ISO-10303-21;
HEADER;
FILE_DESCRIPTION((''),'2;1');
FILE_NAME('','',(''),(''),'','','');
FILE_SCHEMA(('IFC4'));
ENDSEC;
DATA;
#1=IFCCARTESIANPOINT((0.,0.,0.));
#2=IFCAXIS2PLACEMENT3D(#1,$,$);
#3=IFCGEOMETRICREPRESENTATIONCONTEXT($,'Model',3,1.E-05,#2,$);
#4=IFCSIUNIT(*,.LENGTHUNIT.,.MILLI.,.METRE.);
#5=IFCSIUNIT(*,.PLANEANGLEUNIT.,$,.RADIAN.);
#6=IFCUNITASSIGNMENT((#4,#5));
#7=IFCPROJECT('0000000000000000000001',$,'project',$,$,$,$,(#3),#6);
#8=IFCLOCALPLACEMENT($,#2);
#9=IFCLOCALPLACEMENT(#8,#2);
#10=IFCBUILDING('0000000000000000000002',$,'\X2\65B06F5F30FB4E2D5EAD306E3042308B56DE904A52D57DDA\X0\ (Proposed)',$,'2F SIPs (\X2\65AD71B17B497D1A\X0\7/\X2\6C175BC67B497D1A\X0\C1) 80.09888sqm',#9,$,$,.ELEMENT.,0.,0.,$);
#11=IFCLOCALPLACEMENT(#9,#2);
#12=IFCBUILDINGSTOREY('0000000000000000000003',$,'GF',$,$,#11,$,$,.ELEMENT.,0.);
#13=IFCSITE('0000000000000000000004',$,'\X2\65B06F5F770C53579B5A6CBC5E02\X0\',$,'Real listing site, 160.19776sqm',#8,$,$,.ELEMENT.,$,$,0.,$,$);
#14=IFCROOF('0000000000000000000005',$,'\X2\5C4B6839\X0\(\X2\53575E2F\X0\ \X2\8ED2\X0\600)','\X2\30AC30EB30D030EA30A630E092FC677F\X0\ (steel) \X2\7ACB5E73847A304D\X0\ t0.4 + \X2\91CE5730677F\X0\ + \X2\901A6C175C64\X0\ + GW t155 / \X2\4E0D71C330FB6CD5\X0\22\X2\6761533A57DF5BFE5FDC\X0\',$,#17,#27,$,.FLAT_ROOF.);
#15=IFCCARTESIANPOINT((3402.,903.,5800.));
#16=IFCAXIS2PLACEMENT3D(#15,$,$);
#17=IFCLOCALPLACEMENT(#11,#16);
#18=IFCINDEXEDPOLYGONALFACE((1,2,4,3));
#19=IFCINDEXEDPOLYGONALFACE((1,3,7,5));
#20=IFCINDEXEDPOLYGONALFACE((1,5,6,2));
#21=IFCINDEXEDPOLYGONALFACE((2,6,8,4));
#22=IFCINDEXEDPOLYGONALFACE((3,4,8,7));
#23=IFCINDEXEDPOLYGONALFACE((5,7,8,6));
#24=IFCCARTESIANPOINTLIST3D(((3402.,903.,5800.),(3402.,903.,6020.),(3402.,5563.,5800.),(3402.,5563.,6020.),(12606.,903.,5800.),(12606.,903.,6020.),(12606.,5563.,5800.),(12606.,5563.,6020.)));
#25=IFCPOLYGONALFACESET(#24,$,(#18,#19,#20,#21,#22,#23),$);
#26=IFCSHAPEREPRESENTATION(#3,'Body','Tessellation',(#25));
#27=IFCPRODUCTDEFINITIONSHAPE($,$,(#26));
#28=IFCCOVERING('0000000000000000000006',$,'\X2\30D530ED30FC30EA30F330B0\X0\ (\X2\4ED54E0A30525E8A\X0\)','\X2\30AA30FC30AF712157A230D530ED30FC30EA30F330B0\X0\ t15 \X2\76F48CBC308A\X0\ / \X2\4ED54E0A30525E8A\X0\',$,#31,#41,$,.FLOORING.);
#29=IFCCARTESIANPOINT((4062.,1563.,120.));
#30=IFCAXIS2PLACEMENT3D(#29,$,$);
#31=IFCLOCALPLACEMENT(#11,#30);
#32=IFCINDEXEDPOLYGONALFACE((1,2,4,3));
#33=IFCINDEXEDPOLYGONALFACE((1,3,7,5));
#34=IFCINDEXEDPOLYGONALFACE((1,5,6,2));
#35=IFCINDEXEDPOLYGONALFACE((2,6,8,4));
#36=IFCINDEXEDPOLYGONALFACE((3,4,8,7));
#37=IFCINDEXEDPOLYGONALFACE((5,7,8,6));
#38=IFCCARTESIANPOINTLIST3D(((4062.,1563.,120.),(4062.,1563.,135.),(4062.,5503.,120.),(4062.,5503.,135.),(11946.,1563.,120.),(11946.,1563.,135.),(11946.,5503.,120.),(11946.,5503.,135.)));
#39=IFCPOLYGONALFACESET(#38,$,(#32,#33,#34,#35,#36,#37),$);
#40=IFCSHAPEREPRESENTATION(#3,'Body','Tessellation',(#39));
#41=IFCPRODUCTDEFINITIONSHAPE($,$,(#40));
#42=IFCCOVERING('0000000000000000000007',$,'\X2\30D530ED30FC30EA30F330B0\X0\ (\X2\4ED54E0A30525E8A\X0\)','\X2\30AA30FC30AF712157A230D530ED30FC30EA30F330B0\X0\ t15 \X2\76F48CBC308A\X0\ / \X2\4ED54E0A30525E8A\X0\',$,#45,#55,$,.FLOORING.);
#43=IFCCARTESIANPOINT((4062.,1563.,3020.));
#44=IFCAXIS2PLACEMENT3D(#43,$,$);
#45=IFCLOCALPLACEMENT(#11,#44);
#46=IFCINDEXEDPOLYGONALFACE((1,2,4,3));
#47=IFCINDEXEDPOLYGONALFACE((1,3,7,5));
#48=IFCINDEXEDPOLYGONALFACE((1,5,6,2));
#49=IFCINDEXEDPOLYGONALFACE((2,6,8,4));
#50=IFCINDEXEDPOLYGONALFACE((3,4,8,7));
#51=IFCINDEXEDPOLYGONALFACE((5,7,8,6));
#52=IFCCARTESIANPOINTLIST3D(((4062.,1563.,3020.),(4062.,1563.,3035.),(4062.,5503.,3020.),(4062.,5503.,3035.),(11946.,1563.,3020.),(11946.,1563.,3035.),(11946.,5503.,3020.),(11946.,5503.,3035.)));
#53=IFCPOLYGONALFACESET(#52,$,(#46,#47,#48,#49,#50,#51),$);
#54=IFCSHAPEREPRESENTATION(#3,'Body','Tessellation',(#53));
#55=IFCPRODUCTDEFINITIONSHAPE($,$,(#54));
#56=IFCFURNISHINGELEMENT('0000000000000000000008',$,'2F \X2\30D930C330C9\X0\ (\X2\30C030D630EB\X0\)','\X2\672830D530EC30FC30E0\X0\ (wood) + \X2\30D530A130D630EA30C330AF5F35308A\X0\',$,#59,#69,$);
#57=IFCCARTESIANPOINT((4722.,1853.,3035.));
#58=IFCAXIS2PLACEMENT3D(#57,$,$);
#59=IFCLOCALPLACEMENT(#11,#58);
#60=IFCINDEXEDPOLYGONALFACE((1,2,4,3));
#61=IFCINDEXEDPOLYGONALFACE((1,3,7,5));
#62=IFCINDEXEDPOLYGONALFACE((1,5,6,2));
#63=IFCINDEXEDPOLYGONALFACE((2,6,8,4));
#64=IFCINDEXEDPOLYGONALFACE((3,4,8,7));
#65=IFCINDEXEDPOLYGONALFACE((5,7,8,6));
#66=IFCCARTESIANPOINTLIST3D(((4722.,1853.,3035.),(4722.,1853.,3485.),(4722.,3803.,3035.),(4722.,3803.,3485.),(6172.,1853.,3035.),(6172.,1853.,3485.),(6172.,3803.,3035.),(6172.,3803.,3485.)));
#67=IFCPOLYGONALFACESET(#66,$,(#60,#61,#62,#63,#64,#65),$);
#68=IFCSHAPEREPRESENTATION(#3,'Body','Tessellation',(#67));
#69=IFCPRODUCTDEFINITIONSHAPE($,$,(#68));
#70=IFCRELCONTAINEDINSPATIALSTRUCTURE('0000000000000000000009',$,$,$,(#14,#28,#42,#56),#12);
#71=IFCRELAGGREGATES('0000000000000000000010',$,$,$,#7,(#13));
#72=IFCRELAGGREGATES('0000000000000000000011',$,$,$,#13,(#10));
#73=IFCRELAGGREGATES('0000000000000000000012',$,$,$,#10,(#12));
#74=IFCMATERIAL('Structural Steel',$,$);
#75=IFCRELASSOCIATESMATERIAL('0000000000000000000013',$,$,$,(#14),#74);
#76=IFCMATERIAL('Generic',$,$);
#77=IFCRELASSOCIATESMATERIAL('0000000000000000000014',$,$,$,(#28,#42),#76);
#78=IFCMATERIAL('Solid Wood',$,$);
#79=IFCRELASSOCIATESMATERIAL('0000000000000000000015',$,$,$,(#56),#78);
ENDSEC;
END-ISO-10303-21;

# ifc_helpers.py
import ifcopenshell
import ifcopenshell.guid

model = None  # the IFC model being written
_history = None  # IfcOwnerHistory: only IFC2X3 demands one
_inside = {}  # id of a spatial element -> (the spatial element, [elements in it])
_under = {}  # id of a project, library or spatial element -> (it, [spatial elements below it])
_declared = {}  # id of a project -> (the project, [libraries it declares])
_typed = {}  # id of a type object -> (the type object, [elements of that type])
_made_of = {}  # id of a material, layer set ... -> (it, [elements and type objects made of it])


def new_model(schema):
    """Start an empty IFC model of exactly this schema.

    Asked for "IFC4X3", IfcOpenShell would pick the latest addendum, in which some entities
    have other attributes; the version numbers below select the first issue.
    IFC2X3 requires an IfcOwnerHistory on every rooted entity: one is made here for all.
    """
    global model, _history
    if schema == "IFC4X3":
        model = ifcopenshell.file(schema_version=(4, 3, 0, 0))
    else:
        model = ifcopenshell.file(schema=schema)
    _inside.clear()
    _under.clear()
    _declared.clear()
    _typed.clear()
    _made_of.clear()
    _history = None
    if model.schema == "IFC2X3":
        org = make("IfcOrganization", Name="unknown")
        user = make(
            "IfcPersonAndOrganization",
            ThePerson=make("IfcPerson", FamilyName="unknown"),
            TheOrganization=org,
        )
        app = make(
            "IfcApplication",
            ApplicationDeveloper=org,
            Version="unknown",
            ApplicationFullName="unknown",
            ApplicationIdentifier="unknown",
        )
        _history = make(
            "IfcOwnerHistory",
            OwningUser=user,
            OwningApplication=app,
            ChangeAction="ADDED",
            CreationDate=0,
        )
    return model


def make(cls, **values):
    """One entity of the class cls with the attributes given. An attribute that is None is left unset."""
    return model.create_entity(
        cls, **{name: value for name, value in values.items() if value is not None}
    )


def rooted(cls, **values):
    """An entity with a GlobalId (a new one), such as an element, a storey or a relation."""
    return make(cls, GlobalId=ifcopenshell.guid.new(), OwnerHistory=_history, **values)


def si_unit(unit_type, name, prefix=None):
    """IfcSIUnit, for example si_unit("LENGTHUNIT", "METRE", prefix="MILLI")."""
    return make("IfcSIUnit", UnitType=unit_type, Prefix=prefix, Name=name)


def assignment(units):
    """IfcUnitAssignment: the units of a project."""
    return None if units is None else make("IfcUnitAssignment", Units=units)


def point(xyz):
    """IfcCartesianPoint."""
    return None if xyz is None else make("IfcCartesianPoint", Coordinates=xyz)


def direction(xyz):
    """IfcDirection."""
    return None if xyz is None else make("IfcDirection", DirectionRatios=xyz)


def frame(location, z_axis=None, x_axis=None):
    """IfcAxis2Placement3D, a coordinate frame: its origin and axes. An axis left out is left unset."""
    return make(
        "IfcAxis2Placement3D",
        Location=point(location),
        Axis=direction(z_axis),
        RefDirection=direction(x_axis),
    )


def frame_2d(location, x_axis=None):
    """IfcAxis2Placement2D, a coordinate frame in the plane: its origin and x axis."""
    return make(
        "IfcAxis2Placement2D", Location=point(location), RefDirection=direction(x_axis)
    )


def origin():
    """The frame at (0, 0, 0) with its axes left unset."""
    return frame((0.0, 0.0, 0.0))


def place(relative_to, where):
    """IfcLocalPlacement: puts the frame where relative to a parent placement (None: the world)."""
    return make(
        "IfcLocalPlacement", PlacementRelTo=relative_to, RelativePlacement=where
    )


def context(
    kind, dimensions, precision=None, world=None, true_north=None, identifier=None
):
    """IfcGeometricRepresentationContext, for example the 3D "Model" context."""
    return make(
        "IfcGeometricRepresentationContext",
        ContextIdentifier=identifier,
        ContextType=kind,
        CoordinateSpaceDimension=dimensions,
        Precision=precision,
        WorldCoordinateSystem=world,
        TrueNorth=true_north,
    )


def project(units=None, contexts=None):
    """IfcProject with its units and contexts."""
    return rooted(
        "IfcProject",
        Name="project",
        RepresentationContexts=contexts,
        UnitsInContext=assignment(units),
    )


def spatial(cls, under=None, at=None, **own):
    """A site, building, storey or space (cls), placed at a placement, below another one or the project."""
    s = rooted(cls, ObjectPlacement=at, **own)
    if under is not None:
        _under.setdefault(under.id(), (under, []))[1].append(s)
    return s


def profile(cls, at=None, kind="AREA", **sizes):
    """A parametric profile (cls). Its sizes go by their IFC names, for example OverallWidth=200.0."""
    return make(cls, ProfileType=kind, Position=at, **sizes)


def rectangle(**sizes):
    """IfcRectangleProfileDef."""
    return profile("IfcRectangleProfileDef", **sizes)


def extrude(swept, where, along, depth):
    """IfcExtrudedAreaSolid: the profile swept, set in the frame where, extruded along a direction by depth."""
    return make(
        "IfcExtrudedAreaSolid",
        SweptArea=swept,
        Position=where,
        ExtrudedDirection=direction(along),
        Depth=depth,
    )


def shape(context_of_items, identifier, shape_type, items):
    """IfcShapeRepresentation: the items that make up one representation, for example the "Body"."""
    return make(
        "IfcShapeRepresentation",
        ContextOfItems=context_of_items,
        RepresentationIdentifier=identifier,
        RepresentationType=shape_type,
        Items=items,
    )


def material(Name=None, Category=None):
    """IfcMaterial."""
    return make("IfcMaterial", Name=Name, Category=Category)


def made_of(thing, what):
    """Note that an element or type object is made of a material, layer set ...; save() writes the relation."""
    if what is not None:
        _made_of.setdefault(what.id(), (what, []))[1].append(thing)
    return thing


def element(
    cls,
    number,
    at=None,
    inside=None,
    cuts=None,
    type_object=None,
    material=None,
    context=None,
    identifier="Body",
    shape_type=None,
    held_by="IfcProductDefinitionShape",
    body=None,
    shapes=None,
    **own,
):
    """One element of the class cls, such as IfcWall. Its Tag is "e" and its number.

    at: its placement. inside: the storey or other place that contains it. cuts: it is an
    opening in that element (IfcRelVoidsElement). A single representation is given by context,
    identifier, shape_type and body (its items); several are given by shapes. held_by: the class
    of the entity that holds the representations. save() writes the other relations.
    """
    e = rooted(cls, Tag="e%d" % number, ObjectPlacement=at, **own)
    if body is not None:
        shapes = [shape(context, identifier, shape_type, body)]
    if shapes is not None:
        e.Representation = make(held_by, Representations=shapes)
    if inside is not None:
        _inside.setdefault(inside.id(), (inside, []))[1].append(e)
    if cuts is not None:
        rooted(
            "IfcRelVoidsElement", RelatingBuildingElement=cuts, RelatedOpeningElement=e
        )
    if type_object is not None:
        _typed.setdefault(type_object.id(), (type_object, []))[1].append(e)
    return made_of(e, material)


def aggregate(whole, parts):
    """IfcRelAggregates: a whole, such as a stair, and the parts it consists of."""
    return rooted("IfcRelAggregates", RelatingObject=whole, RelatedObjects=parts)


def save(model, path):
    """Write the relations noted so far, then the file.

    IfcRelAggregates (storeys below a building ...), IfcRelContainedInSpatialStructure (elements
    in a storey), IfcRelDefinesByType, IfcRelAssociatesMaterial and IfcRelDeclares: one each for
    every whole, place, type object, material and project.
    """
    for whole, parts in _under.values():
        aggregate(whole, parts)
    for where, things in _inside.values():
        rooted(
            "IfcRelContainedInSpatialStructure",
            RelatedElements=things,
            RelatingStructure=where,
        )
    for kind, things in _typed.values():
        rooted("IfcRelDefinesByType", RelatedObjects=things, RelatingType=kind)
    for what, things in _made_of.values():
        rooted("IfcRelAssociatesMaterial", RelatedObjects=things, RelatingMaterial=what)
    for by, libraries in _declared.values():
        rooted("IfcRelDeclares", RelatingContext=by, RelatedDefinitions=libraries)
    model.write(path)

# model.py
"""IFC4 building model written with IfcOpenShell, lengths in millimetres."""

from ifc_helpers import new_model, si_unit, frame, frame_2d, origin, place, context, project, spatial, rectangle, extrude, material, element, save


model = new_model("IFC4")

# Units and contexts
model_context = context("Model", 3, precision=1e-05, world=origin())
ifc_project = project(units=[si_unit("LENGTHUNIT", "METRE", prefix="MILLI"), si_unit("PLANEANGLEUNIT", "RADIAN")], contexts=[model_context])

# Site, building, storey
site_placement = place(None, origin())
site = spatial("IfcSite", under=ifc_project, at=site_placement, Name="新潟県南魚沼市", ObjectType="Real listing site, 160.19776sqm", CompositionType="ELEMENT", RefElevation=0.0)
building_placement = place(site_placement, origin())
building = spatial("IfcBuilding", under=site, at=building_placement, Name="新潟・中庭のある回遊動線 (Proposed)", ObjectType="2F SIPs (断熱等級7/気密等級C1) 80.09888sqm", CompositionType="ELEMENT", ElevationOfRefHeight=0.0, ElevationOfTerrain=0.0)
storey_placement = place(building_placement, origin())
storey = spatial("IfcBuildingStorey", under=building, at=storey_placement, Name="GF", CompositionType="ELEMENT", Elevation=0.0)

# Shared definitions
ifc_material_1 = material(Name="Solid Wood")

# Roof
ifc_material_2 = material(Name="Structural Steel")
for number, where, name in (
    (1, (3402.0, 903.0, 5800.0), "屋根(南帯 軒600)"),
):
    element("IfcRoof", number, at=place(storey_placement, frame(where)), inside=storey, material=ifc_material_2, Name=name, Description="ガルバリウム鋼板 (steel) 立平葺き t0.4 + 野地板 + 通気層 + GW t155 / 不燃・法22条区域対応", PredefinedType="FLAT_ROOF", context=model_context, shape_type="SweptSolid", body=[
        extrude(rectangle(XDim=9204.0, YDim=4660.0, at=frame_2d((4602.0, 2330.0))), frame((3402.0, 903.0, 5800.0)), (0.0, 0.0, 1.0), 220.0),
    ])

# Coverings
ifc_material_3 = material(Name="Generic")
covering_1_placement = place(storey_placement, frame((4062.0, 1563.0, 120.0)))
element("IfcCovering", 2, at=covering_1_placement, inside=storey, material=ifc_material_3, Name="フローリング (仕上げ床)", Description="オーク無垢フローリング t15 直貼り / 仕上げ床", PredefinedType="FLOORING", context=model_context, shape_type="SweptSolid", body=[
    extrude(rectangle(XDim=7884.0, YDim=3940.0, at=frame_2d((3942.0, 1970.0))), frame((4062.0, 1563.0, 120.0)), (0.0, 0.0, 1.0), 15.0),
])
covering_2_placement = place(storey_placement, frame((4062.0, 1563.0, 3020.0)))
element("IfcCovering", 3, at=covering_2_placement, inside=storey, material=ifc_material_3, Name="フローリング (仕上げ床)", Description="オーク無垢フローリング t15 直貼り / 仕上げ床", PredefinedType="FLOORING", context=model_context, shape_type="SweptSolid", body=[
    extrude(rectangle(XDim=7884.0, YDim=3940.0, at=frame_2d((3942.0, 1970.0))), frame((4062.0, 1563.0, 3020.0)), (0.0, 0.0, 1.0), 15.0),
])

# Furnishing element
furnishing_placement = place(storey_placement, frame((4722.0, 1853.0, 3035.0)))
element("IfcFurnishingElement", 4, at=furnishing_placement, inside=storey, material=ifc_material_1, Name="2F ベッド (ダブル)", Description="木フレーム (wood) + ファブリック張り", context=model_context, shape_type="SweptSolid", body=[
    extrude(rectangle(XDim=1450.0, YDim=1950.0, at=frame_2d((725.0, 975.0))), frame((4722.0, 1853.0, 3035.0)), (0.0, 0.0, 1.0), 450.0),
])

save(model, "model.ifc")
